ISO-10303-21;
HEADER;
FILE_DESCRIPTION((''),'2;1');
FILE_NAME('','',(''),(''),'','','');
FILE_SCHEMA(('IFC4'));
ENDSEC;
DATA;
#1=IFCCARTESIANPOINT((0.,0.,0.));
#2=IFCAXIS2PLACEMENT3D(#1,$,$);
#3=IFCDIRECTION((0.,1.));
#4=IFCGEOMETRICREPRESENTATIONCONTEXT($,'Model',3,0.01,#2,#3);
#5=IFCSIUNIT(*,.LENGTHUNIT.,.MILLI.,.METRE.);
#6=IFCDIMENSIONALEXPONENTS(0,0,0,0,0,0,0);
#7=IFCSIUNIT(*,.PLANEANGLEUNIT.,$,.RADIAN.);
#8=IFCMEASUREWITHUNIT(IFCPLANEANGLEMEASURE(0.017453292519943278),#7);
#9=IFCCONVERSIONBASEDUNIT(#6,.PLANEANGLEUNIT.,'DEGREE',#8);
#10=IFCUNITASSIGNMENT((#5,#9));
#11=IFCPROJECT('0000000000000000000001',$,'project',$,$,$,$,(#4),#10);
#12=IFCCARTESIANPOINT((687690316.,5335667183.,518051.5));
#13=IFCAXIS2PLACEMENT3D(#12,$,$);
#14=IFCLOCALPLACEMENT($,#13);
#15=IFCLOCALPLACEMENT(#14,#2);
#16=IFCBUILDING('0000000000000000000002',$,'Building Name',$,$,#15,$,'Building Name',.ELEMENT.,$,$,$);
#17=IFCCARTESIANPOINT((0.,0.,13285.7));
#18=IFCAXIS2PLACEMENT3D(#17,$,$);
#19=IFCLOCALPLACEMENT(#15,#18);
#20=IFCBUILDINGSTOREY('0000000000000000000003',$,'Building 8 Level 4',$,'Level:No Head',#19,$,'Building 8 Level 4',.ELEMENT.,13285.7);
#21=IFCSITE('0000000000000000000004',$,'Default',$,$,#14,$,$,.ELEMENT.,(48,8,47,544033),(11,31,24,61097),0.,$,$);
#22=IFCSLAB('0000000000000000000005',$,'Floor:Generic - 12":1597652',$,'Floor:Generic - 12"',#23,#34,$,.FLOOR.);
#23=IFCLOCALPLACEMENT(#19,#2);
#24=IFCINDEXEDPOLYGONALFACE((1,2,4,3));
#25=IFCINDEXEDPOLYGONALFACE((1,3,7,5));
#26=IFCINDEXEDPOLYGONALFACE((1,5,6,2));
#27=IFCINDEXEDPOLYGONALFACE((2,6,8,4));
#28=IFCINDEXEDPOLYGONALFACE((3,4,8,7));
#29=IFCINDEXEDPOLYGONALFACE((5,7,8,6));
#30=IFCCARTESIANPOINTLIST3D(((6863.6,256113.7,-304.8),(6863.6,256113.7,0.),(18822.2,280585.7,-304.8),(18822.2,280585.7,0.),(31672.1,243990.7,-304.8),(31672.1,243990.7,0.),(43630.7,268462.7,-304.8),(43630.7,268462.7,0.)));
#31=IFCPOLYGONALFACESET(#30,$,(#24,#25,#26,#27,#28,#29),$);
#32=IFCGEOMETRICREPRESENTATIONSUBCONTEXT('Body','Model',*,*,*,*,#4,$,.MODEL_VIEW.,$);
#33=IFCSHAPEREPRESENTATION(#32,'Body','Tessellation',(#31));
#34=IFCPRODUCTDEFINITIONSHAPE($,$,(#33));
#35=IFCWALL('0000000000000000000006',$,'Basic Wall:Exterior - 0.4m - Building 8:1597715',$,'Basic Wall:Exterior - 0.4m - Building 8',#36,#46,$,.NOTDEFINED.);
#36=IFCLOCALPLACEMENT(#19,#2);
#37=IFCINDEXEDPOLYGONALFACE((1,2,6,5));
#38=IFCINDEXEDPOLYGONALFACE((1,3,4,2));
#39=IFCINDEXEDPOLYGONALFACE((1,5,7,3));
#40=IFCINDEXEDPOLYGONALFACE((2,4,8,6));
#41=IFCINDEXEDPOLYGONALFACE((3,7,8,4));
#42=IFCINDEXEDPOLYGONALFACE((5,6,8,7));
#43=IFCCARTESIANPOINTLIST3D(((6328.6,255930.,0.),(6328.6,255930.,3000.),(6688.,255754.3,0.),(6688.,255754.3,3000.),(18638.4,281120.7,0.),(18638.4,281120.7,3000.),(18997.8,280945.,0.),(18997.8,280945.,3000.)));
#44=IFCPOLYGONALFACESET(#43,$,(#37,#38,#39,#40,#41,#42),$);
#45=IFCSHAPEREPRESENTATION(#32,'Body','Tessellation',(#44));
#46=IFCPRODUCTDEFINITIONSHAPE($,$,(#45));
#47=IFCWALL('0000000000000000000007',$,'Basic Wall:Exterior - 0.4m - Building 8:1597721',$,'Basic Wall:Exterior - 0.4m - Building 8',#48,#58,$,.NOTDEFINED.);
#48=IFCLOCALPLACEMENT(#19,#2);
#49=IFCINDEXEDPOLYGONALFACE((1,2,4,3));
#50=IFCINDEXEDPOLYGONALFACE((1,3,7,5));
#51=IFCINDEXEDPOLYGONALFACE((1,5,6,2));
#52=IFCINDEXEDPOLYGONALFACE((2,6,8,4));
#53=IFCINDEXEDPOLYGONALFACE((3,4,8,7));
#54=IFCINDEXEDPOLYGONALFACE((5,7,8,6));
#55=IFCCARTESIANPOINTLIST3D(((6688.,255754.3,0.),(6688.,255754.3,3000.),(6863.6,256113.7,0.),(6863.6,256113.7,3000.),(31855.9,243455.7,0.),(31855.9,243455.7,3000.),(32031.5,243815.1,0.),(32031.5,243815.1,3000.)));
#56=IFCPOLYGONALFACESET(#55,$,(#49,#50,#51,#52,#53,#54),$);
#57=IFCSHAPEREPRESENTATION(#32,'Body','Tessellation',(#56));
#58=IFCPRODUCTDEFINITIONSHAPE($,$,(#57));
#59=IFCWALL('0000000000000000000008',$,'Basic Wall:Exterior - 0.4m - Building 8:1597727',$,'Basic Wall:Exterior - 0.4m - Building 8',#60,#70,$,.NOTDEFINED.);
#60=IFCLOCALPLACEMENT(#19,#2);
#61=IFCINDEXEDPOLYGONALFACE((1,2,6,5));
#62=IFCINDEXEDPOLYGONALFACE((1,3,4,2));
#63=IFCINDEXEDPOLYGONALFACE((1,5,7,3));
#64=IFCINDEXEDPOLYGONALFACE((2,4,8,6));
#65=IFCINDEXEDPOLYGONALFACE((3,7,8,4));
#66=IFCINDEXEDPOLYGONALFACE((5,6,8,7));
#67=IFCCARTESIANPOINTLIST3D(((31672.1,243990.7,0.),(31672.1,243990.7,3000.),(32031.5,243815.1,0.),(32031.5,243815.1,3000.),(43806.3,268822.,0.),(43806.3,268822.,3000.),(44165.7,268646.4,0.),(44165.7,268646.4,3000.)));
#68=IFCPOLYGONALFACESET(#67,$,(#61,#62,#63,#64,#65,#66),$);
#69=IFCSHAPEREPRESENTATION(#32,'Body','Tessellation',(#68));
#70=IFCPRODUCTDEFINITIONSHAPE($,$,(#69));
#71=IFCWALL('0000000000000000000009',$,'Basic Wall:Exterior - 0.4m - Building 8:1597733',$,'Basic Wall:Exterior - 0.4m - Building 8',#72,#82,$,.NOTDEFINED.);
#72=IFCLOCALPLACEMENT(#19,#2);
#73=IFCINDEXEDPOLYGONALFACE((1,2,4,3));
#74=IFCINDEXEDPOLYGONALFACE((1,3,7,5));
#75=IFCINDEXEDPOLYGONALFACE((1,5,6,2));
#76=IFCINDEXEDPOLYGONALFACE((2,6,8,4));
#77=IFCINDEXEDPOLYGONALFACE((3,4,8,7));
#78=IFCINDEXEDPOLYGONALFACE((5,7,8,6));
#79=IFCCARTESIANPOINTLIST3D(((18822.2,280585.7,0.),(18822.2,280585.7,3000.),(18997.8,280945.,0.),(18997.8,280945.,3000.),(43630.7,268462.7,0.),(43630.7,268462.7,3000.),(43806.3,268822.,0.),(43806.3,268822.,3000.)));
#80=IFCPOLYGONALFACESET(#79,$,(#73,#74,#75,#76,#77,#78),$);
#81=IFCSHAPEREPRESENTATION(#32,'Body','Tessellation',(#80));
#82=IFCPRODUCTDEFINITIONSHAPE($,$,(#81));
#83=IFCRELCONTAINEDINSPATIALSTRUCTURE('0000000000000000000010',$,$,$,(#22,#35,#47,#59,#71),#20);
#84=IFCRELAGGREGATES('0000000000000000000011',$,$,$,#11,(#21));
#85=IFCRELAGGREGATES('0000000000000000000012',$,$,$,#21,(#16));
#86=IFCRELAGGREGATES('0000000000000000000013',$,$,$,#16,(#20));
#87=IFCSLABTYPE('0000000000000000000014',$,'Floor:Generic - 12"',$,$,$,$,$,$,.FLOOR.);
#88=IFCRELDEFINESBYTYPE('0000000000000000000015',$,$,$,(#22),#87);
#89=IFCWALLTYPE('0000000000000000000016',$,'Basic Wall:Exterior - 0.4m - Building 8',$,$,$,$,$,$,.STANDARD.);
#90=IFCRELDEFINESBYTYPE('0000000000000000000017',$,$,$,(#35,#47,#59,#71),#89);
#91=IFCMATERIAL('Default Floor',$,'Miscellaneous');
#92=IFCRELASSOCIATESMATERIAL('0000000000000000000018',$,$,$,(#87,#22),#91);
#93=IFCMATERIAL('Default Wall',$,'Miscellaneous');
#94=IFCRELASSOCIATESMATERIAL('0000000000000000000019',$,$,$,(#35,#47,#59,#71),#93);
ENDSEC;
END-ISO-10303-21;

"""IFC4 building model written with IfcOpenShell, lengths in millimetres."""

from ifc_helpers import new_model, entity, si_unit, converted_unit, direction, frame, origin, place, context, subcontext, project, spatial, indexed_curve, outline, extrude, material, type_object, element, save


model = new_model("IFC4")

# Units and contexts
model_context = context("Model", 3, precision=0.01, world=origin(), true_north=direction((0.0, 1.0)))
body_context = subcontext(model_context, "Body", "Model", "MODEL_VIEW")
ifc_project = project(units=[si_unit("LENGTHUNIT", "METRE", prefix="MILLI"), converted_unit("PLANEANGLEUNIT", "DEGREE", entity("IfcPlaneAngleMeasure", 0.017453292519943278), si_unit("PLANEANGLEUNIT", "RADIAN"), dimensions=[0, 0, 0, 0, 0, 0, 0])], contexts=[model_context])

# Site, building, storey
site_placement = place(None, frame((687690316.0, 5335667183.0, 518051.5)))
site = spatial("IfcSite", under=ifc_project, at=site_placement, Name="Default", CompositionType="ELEMENT", RefLatitude=(48, 8, 47, 544033), RefLongitude=(11, 31, 24, 61097), RefElevation=0.0)
building_placement = place(site_placement, origin())
building = spatial("IfcBuilding", under=site, at=building_placement, Name="Building Name", LongName="Building Name", CompositionType="ELEMENT")
storey_placement = place(building_placement, frame((0.0, 0.0, 13285.7)))
storey = spatial("IfcBuildingStorey", under=building, at=storey_placement, Name="Building 8 Level 4", ObjectType="Level:No Head", LongName="Building 8 Level 4", CompositionType="ELEMENT", Elevation=13285.7)

# Slab
ifc_material_1 = material(Name="Default Floor", Category="Miscellaneous")
slab_type = type_object("IfcSlabType", Name="Floor:Generic - 12\"", PredefinedType="FLOOR", material=ifc_material_1)
slab_placement = place(storey_placement, origin())
element("IfcSlab", 1, at=slab_placement, inside=storey, type_object=slab_type, material=ifc_material_1, Name="Floor:Generic - 12\":1597652", ObjectType="Floor:Generic - 12\"", PredefinedType="FLOOR", context=body_context, shape_type="SweptSolid", body=[
    extrude(outline(indexed_curve([(-13806.1, -13618.8), (13806.1, -13618.8), (13806.1, 13618.8), (-13806.1, 13618.8), (-13806.1, -13618.8)], self_intersect=False)), frame((25247.1, 262288.2, 0.0), z_axis=(0.0, 0.0, -1.0), x_axis=(0.898464, -0.439046, 0.0)), (0.0, 0.0, 1.0), 304.8),
])

# Walls
ifc_material_2 = material(Name="Default Wall", Category="Miscellaneous")
wall_type = type_object("IfcWallType", Name="Basic Wall:Exterior - 0.4m - Building 8", PredefinedType="STANDARD")
wall_1_placement = place(storey_placement, frame((18818.1, 281032.9, 0.0), z_axis=(0.0, 0.0, 1.0), x_axis=(-0.439046, -0.898464, 0.0)))
element("IfcWall", 2, at=wall_1_placement, inside=storey, type_object=wall_type, material=ifc_material_2, Name="Basic Wall:Exterior - 0.4m - Building 8:1597715", ObjectType="Basic Wall:Exterior - 0.4m - Building 8", PredefinedType="NOTDEFINED", context=body_context, shape_type="SweptSolid", body=[
    extrude(outline(indexed_curve([(28037.5, 200.0), (0.0, 200.0), (0.0, -200.0), (28037.5, -200.0), (28037.5, 200.0)], self_intersect=False)), origin(), (0.0, 0.0, 1.0), 3000.0),
])
wall_2_placement = place(storey_placement, frame((6775.8, 255934.0, 0.0), z_axis=(0.0, 0.0, 1.0), x_axis=(0.898464, -0.439046, 0.0)))
element("IfcWall", 3, at=wall_2_placement, inside=storey, type_object=wall_type, material=ifc_material_2, Name="Basic Wall:Exterior - 0.4m - Building 8:1597721", ObjectType="Basic Wall:Exterior - 0.4m - Building 8", PredefinedType="NOTDEFINED", context=body_context, shape_type="SweptSolid", body=[
    extrude(outline(indexed_curve([(28012.1, 200.0), (0.0, 200.0), (0.0, -200.0), (28012.1, -200.0), (28012.1, 200.0)], self_intersect=False)), origin(), (0.0, 0.0, 1.0), 3000.0),
])
wall_3_placement = place(storey_placement, frame((31851.8, 243902.9, 0.0), z_axis=(0.0, 0.0, 1.0), x_axis=(0.439046, 0.898464, 0.0)))
element("IfcWall", 4, at=wall_3_placement, inside=storey, type_object=wall_type, material=ifc_material_2, Name="Basic Wall:Exterior - 0.4m - Building 8:1597727", ObjectType="Basic Wall:Exterior - 0.4m - Building 8", PredefinedType="NOTDEFINED", context=body_context, shape_type="SweptSolid", body=[
    extrude(outline(indexed_curve([(27637.5, 200.0), (0.0, 200.0), (0.0, -200.0), (27637.5, -200.0), (27637.5, 200.0)], self_intersect=False)), origin(), (0.0, 0.0, 1.0), 3000.0),
])
wall_4_placement = place(storey_placement, frame((43718.5, 268642.3, 0.0), z_axis=(0.0, 0.0, 1.0), x_axis=(-0.898464, 0.439046, 0.0)))
element("IfcWall", 5, at=wall_4_placement, inside=storey, type_object=wall_type, material=ifc_material_2, Name="Basic Wall:Exterior - 0.4m - Building 8:1597733", ObjectType="Basic Wall:Exterior - 0.4m - Building 8", PredefinedType="NOTDEFINED", context=body_context, shape_type="SweptSolid", body=[
    extrude(outline(indexed_curve([(27612.1, 200.0), (0.0, 200.0), (0.0, -200.0), (27612.1, -200.0), (27612.1, 200.0)], self_intersect=False)), origin(), (0.0, 0.0, 1.0), 3000.0),
])

save(model, "model.ifc")
